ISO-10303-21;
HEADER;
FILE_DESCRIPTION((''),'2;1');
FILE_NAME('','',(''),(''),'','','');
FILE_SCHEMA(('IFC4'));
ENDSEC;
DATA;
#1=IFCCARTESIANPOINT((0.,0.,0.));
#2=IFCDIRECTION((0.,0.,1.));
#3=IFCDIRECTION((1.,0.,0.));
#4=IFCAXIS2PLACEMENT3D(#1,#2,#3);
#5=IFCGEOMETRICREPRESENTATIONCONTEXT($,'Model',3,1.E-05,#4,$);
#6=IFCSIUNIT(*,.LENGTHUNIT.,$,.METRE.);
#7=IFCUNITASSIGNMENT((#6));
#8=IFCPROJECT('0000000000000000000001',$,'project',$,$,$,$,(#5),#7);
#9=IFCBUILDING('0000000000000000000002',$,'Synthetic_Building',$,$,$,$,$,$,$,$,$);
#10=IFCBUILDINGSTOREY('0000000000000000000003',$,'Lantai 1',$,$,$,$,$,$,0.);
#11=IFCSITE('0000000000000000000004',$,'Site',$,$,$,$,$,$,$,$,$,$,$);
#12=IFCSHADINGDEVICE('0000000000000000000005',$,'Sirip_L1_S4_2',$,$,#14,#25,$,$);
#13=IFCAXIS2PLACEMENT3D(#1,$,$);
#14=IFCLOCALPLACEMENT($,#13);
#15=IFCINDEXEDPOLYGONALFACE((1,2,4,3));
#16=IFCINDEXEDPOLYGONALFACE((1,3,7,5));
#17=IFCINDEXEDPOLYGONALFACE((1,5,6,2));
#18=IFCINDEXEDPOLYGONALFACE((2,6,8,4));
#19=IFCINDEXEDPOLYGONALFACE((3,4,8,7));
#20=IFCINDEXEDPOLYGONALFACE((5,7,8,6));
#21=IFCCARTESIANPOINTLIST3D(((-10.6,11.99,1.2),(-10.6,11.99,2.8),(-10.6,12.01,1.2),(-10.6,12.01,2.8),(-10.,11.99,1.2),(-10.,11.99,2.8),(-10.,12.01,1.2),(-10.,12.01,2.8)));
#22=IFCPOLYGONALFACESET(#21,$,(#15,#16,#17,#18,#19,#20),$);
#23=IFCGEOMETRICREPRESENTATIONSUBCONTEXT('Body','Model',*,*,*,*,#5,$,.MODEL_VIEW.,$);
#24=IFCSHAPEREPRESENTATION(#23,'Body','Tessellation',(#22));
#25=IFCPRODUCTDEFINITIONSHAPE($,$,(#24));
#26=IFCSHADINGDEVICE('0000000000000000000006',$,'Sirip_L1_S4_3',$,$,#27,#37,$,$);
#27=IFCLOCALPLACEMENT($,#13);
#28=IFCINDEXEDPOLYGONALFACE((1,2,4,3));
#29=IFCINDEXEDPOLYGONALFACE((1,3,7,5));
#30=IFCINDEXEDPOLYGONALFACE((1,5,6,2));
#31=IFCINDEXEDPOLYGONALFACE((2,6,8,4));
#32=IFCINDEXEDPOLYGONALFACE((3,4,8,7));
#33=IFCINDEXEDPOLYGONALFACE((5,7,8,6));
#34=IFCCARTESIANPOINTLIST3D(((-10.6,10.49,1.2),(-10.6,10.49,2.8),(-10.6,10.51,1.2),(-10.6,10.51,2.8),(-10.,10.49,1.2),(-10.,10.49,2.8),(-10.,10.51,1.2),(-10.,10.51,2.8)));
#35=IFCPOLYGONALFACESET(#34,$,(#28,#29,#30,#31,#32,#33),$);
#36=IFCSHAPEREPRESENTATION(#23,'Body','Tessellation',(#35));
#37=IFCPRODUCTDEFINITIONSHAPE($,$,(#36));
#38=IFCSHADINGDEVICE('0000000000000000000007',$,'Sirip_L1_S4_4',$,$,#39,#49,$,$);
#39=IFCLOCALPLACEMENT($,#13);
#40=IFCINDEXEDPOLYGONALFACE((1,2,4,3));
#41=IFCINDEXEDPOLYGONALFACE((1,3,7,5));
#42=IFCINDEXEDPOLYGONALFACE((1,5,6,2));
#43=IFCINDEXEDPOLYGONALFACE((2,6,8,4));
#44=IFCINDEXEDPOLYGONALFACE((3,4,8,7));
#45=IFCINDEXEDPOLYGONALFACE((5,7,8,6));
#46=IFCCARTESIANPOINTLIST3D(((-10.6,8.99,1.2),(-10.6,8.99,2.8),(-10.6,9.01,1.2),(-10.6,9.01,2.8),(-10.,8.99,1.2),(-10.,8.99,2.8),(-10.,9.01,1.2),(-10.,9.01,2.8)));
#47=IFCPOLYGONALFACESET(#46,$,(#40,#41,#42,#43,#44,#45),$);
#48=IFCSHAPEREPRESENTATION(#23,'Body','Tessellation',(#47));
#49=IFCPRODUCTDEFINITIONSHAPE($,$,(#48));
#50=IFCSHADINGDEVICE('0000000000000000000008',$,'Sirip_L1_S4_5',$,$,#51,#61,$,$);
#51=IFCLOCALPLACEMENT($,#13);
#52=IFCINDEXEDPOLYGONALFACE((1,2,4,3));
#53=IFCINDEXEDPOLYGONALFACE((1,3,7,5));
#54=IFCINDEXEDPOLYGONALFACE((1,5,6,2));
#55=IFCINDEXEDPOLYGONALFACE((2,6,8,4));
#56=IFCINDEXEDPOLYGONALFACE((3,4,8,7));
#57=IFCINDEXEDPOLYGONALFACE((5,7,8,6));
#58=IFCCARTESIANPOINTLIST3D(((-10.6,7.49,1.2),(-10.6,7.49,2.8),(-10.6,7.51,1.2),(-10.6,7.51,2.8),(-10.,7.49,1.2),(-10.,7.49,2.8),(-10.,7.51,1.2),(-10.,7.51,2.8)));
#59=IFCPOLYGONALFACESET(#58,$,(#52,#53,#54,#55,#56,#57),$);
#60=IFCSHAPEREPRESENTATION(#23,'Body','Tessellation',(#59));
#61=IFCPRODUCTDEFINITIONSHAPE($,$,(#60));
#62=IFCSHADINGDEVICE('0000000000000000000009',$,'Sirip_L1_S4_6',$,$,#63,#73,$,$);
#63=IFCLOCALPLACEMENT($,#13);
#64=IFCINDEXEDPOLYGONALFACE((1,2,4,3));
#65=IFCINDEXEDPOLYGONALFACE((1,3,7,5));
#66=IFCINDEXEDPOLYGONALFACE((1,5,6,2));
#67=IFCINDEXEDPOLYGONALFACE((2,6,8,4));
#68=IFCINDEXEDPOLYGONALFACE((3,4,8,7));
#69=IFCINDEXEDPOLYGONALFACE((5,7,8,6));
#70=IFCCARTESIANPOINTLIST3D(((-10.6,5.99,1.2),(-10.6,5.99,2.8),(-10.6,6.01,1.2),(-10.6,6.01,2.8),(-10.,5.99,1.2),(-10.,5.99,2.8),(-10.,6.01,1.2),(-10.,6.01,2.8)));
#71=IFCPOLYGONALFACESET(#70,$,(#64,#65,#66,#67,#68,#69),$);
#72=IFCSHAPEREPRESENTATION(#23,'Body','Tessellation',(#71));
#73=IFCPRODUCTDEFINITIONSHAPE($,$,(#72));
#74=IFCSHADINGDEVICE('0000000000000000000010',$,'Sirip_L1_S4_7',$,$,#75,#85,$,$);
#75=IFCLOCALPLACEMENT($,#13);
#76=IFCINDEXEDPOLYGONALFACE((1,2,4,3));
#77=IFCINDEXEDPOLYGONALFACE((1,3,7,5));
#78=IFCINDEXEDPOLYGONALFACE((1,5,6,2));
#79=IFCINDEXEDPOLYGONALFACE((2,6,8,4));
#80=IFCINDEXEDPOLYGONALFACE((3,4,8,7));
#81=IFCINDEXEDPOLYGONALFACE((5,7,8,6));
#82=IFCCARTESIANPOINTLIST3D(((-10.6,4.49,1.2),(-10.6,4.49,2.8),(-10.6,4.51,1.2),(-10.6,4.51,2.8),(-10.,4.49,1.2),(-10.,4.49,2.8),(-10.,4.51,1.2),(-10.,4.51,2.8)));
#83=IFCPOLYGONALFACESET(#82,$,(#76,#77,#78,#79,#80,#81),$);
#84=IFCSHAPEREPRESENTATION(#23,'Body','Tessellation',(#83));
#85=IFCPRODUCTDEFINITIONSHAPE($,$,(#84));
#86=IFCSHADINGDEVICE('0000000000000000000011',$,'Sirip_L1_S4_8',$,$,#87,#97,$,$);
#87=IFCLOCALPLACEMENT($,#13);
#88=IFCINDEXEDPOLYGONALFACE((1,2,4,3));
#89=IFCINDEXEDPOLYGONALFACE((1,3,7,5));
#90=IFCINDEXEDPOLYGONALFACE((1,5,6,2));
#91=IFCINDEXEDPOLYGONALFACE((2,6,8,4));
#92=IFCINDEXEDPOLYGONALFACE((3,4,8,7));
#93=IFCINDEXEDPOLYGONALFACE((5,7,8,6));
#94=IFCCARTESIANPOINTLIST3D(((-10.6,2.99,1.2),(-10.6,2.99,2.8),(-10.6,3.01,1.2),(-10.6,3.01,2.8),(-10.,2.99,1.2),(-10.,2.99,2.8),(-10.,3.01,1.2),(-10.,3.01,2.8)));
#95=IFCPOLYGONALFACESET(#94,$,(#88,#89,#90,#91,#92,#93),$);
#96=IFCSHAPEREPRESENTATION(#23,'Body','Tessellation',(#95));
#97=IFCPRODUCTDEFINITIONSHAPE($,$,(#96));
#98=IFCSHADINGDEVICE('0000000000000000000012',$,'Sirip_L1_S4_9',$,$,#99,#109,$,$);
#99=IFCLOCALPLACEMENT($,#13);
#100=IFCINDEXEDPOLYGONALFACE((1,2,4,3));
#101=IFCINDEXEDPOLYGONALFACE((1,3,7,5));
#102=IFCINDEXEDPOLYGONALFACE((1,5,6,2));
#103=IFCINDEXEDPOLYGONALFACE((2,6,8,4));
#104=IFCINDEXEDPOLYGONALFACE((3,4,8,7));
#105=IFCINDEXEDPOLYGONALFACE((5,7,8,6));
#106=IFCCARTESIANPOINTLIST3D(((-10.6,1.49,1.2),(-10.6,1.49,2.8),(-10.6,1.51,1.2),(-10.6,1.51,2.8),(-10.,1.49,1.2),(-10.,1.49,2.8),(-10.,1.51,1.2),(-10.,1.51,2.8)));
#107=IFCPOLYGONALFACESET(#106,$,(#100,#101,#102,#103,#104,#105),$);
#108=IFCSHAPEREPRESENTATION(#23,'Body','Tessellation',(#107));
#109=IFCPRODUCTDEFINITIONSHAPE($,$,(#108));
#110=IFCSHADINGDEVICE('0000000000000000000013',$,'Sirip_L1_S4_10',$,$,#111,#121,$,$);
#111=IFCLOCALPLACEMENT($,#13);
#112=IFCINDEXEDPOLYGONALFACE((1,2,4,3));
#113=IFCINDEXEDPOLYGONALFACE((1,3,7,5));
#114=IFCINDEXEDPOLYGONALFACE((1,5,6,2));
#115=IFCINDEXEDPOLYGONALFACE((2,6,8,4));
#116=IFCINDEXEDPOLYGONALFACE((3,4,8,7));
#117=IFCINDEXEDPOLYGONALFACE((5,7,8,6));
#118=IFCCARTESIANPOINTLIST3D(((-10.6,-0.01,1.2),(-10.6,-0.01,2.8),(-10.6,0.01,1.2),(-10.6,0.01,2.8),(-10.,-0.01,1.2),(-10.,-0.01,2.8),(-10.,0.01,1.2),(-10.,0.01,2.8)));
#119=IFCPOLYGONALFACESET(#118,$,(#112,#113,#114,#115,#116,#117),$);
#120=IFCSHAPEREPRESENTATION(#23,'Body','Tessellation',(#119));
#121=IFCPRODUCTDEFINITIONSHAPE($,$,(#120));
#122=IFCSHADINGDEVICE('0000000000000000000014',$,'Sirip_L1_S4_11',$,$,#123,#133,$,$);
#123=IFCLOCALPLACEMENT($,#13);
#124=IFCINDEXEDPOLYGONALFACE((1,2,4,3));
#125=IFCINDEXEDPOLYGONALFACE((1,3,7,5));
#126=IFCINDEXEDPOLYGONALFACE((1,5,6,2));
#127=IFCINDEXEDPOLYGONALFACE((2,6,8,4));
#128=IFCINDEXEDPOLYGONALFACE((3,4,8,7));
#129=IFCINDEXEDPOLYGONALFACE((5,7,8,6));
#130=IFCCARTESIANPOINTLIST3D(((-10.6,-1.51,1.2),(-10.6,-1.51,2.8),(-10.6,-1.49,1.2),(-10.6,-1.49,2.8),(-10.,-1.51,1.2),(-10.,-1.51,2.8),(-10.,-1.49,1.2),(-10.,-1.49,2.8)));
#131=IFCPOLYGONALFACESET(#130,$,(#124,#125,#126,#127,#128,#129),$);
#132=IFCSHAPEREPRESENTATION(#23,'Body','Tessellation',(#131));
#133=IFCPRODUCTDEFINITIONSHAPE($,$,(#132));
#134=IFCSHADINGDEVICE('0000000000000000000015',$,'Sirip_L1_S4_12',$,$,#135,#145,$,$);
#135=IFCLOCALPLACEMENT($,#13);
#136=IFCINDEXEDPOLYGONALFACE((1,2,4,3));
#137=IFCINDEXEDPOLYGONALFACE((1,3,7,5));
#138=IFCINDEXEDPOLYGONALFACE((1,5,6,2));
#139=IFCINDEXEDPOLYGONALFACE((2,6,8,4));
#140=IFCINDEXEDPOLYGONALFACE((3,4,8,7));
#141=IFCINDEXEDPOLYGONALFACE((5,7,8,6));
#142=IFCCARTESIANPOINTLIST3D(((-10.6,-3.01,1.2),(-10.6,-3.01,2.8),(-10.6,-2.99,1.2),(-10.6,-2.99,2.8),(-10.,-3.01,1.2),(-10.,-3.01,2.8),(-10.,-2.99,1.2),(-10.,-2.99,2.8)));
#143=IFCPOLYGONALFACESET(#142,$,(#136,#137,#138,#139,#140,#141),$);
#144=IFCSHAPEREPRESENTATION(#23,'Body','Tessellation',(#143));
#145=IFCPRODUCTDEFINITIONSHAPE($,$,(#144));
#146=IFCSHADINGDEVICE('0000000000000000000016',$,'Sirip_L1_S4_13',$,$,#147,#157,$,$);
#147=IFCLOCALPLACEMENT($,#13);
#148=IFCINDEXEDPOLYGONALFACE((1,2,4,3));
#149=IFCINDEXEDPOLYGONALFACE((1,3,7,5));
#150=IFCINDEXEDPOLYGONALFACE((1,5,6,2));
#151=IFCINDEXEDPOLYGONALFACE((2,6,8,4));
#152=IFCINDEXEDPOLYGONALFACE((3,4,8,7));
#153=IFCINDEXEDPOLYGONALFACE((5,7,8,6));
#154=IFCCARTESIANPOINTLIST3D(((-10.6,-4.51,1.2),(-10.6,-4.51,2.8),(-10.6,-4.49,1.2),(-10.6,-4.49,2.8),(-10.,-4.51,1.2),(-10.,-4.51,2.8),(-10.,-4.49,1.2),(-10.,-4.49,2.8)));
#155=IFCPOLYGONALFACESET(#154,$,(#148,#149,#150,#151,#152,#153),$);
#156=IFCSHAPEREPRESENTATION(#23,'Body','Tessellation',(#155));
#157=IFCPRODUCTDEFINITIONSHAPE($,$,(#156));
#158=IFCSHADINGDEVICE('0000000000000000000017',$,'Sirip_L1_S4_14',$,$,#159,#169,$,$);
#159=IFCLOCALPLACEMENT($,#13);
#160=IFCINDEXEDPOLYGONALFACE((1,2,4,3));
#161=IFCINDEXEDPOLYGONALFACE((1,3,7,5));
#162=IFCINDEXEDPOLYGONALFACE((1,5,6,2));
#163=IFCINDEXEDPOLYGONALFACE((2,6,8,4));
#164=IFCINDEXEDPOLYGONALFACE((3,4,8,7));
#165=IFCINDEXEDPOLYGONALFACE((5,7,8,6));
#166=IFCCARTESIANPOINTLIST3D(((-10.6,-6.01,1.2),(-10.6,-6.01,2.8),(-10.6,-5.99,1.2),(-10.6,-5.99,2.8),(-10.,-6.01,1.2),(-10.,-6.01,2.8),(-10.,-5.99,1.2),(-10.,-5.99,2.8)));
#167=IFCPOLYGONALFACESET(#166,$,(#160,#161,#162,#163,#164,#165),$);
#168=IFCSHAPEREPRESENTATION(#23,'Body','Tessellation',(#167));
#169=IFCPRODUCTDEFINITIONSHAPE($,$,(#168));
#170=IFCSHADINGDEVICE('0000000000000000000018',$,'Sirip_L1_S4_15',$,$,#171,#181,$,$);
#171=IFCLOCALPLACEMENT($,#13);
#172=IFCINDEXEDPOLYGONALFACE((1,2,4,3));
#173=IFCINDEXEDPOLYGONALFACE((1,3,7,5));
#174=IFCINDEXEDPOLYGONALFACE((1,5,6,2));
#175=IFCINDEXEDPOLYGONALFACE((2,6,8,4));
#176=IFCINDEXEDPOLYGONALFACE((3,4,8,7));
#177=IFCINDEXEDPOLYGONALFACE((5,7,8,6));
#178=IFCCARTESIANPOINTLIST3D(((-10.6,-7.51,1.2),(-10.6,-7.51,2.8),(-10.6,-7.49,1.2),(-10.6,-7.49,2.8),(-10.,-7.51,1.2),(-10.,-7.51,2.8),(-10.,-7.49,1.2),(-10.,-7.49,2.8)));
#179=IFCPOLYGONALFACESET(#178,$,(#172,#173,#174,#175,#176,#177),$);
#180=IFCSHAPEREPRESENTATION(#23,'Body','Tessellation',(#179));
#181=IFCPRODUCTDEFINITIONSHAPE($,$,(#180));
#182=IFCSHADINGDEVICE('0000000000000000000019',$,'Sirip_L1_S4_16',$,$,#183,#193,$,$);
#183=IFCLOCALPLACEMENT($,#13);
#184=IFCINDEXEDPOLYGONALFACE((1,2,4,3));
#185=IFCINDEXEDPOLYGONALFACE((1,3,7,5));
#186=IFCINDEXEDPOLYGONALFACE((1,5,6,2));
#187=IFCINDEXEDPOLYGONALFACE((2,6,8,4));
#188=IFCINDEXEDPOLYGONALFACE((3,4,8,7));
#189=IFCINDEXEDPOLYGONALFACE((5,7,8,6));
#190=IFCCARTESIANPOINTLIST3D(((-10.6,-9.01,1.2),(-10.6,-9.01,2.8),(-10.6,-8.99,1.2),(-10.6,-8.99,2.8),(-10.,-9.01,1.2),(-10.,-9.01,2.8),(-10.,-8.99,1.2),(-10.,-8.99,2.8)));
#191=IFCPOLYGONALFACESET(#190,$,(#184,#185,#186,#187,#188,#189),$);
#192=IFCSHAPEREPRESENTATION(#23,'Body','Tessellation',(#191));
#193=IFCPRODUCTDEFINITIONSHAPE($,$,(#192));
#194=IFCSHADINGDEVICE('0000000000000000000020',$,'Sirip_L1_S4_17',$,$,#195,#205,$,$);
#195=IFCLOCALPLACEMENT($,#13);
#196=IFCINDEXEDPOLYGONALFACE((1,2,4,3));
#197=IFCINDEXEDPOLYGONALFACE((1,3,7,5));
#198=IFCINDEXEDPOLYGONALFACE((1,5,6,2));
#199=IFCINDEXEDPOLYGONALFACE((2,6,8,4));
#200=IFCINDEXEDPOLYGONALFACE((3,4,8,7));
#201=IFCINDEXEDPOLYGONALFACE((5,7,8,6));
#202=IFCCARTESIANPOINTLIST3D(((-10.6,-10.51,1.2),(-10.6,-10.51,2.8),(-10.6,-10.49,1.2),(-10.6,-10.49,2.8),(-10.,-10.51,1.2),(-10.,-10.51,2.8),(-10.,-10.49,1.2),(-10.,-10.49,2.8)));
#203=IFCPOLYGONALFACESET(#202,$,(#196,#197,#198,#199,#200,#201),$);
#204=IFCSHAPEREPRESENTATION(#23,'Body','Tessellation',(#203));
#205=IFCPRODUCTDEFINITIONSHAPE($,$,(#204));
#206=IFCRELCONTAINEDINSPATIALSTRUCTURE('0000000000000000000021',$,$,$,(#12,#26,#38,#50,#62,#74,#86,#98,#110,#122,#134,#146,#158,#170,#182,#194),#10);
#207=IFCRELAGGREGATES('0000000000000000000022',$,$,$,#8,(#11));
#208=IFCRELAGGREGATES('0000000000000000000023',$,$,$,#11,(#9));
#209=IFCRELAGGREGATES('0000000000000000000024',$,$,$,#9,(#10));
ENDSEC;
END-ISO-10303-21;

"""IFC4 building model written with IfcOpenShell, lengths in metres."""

from ifc_helpers import new_model, si_unit, frame, origin_with_axes, place, context, subcontext, project, spatial, polyline, outline, extrude, element, save


model = new_model("IFC4")

# Units and contexts
model_context = context("Model", 3, precision=1e-05, world=origin_with_axes())
body_context = subcontext(model_context, "Body", "Model", "MODEL_VIEW")
ifc_project = project(units=[si_unit("LENGTHUNIT", "METRE")], contexts=[model_context])

# Site, building, storey
site = spatial("IfcSite", under=ifc_project, Name="Site")
building = spatial("IfcBuilding", under=site, Name="Synthetic_Building")
storey = spatial("IfcBuildingStorey", under=building, Name="Lantai 1", Elevation=0.0)

# Shading devices
shading_device_1_placement = place(None, origin_with_axes())
element("IfcShadingDevice", 1, at=shading_device_1_placement, inside=storey, Name="Sirip_L1_S4_2", context=body_context, shape_type="SweptSolid", body=[
    extrude(outline(polyline([(-10.0, 12.01), (-10.0, 11.99), (-10.6, 11.99), (-10.6, 12.01), (-10.0, 12.01)])), frame((0.0, 0.0, 1.2), z_axis=(0.0, 0.0, 1.0), x_axis=(1.0, 0.0, 0.0)), (0.0, 0.0, 1.0), 1.6),
])
shading_device_2_placement = place(None, origin_with_axes())
element("IfcShadingDevice", 2, at=shading_device_2_placement, inside=storey, Name="Sirip_L1_S4_3", context=body_context, shape_type="SweptSolid", body=[
    extrude(outline(polyline([(-10.0, 10.51), (-10.0, 10.49), (-10.6, 10.49), (-10.6, 10.51), (-10.0, 10.51)])), frame((0.0, 0.0, 1.2), z_axis=(0.0, 0.0, 1.0), x_axis=(1.0, 0.0, 0.0)), (0.0, 0.0, 1.0), 1.6),
])
shading_device_3_placement = place(None, origin_with_axes())
element("IfcShadingDevice", 3, at=shading_device_3_placement, inside=storey, Name="Sirip_L1_S4_4", context=body_context, shape_type="SweptSolid", body=[
    extrude(outline(polyline([(-10.0, 9.01), (-10.0, 8.99), (-10.6, 8.99), (-10.6, 9.01), (-10.0, 9.01)])), frame((0.0, 0.0, 1.2), z_axis=(0.0, 0.0, 1.0), x_axis=(1.0, 0.0, 0.0)), (0.0, 0.0, 1.0), 1.6),
])
shading_device_4_placement = place(None, origin_with_axes())
element("IfcShadingDevice", 4, at=shading_device_4_placement, inside=storey, Name="Sirip_L1_S4_5", context=body_context, shape_type="SweptSolid", body=[
    extrude(outline(polyline([(-10.0, 7.51), (-10.0, 7.49), (-10.6, 7.49), (-10.6, 7.51), (-10.0, 7.51)])), frame((0.0, 0.0, 1.2), z_axis=(0.0, 0.0, 1.0), x_axis=(1.0, 0.0, 0.0)), (0.0, 0.0, 1.0), 1.6),
])
shading_device_5_placement = place(None, origin_with_axes())
element("IfcShadingDevice", 5, at=shading_device_5_placement, inside=storey, Name="Sirip_L1_S4_6", context=body_context, shape_type="SweptSolid", body=[
    extrude(outline(polyline([(-10.0, 6.01), (-10.0, 5.99), (-10.6, 5.99), (-10.6, 6.01), (-10.0, 6.01)])), frame((0.0, 0.0, 1.2), z_axis=(0.0, 0.0, 1.0), x_axis=(1.0, 0.0, 0.0)), (0.0, 0.0, 1.0), 1.6),
])
shading_device_6_placement = place(None, origin_with_axes())
element("IfcShadingDevice", 6, at=shading_device_6_placement, inside=storey, Name="Sirip_L1_S4_7", context=body_context, shape_type="SweptSolid", body=[
    extrude(outline(polyline([(-10.0, 4.51), (-10.0, 4.49), (-10.6, 4.49), (-10.6, 4.51), (-10.0, 4.51)])), frame((0.0, 0.0, 1.2), z_axis=(0.0, 0.0, 1.0), x_axis=(1.0, 0.0, 0.0)), (0.0, 0.0, 1.0), 1.6),
])
shading_device_7_placement = place(None, origin_with_axes())
element("IfcShadingDevice", 7, at=shading_device_7_placement, inside=storey, Name="Sirip_L1_S4_8", context=body_context, shape_type="SweptSolid", body=[
    extrude(outline(polyline([(-10.0, 3.01), (-10.0, 2.99), (-10.6, 2.99), (-10.6, 3.01), (-10.0, 3.01)])), frame((0.0, 0.0, 1.2), z_axis=(0.0, 0.0, 1.0), x_axis=(1.0, 0.0, 0.0)), (0.0, 0.0, 1.0), 1.6),
])
shading_device_8_placement = place(None, origin_with_axes())
element("IfcShadingDevice", 8, at=shading_device_8_placement, inside=storey, Name="Sirip_L1_S4_9", context=body_context, shape_type="SweptSolid", body=[
    extrude(outline(polyline([(-10.0, 1.51), (-10.0, 1.49), (-10.6, 1.49), (-10.6, 1.51), (-10.0, 1.51)])), frame((0.0, 0.0, 1.2), z_axis=(0.0, 0.0, 1.0), x_axis=(1.0, 0.0, 0.0)), (0.0, 0.0, 1.0), 1.6),
])
shading_device_9_placement = place(None, origin_with_axes())
element("IfcShadingDevice", 9, at=shading_device_9_placement, inside=storey, Name="Sirip_L1_S4_10", context=body_context, shape_type="SweptSolid", body=[
    extrude(outline(polyline([(-10.0, 0.01), (-10.0, -0.01), (-10.6, -0.01), (-10.6, 0.01), (-10.0, 0.01)])), frame((0.0, 0.0, 1.2), z_axis=(0.0, 0.0, 1.0), x_axis=(1.0, 0.0, 0.0)), (0.0, 0.0, 1.0), 1.6),
])
shading_device_10_placement = place(None, origin_with_axes())
element("IfcShadingDevice", 10, at=shading_device_10_placement, inside=storey, Name="Sirip_L1_S4_11", context=body_context, shape_type="SweptSolid", body=[
    extrude(outline(polyline([(-10.0, -1.49), (-10.0, -1.51), (-10.6, -1.51), (-10.6, -1.49), (-10.0, -1.49)])), frame((0.0, 0.0, 1.2), z_axis=(0.0, 0.0, 1.0), x_axis=(1.0, 0.0, 0.0)), (0.0, 0.0, 1.0), 1.6),
])
shading_device_11_placement = place(None, origin_with_axes())
element("IfcShadingDevice", 11, at=shading_device_11_placement, inside=storey, Name="Sirip_L1_S4_12", context=body_context, shape_type="SweptSolid", body=[
    extrude(outline(polyline([(-10.0, -2.99), (-10.0, -3.01), (-10.6, -3.01), (-10.6, -2.99), (-10.0, -2.99)])), frame((0.0, 0.0, 1.2), z_axis=(0.0, 0.0, 1.0), x_axis=(1.0, 0.0, 0.0)), (0.0, 0.0, 1.0), 1.6),
])
shading_device_12_placement = place(None, origin_with_axes())
element("IfcShadingDevice", 12, at=shading_device_12_placement, inside=storey, Name="Sirip_L1_S4_13", context=body_context, shape_type="SweptSolid", body=[
    extrude(outline(polyline([(-10.0, -4.49), (-10.0, -4.51), (-10.6, -4.51), (-10.6, -4.49), (-10.0, -4.49)])), frame((0.0, 0.0, 1.2), z_axis=(0.0, 0.0, 1.0), x_axis=(1.0, 0.0, 0.0)), (0.0, 0.0, 1.0), 1.6),
])
shading_device_13_placement = place(None, origin_with_axes())
element("IfcShadingDevice", 13, at=shading_device_13_placement, inside=storey, Name="Sirip_L1_S4_14", context=body_context, shape_type="SweptSolid", body=[
    extrude(outline(polyline([(-10.0, -5.99), (-10.0, -6.01), (-10.6, -6.01), (-10.6, -5.99), (-10.0, -5.99)])), frame((0.0, 0.0, 1.2), z_axis=(0.0, 0.0, 1.0), x_axis=(1.0, 0.0, 0.0)), (0.0, 0.0, 1.0), 1.6),
])
shading_device_14_placement = place(None, origin_with_axes())
element("IfcShadingDevice", 14, at=shading_device_14_placement, inside=storey, Name="Sirip_L1_S4_15", context=body_context, shape_type="SweptSolid", body=[
    extrude(outline(polyline([(-10.0, -7.49), (-10.0, -7.51), (-10.6, -7.51), (-10.6, -7.49), (-10.0, -7.49)])), frame((0.0, 0.0, 1.2), z_axis=(0.0, 0.0, 1.0), x_axis=(1.0, 0.0, 0.0)), (0.0, 0.0, 1.0), 1.6),
])
shading_device_15_placement = place(None, origin_with_axes())
element("IfcShadingDevice", 15, at=shading_device_15_placement, inside=storey, Name="Sirip_L1_S4_16", context=body_context, shape_type="SweptSolid", body=[
    extrude(outline(polyline([(-10.0, -8.99), (-10.0, -9.01), (-10.6, -9.01), (-10.6, -8.99), (-10.0, -8.99)])), frame((0.0, 0.0, 1.2), z_axis=(0.0, 0.0, 1.0), x_axis=(1.0, 0.0, 0.0)), (0.0, 0.0, 1.0), 1.6),
])
shading_device_16_placement = place(None, origin_with_axes())
element("IfcShadingDevice", 16, at=shading_device_16_placement, inside=storey, Name="Sirip_L1_S4_17", context=body_context, shape_type="SweptSolid", body=[
    extrude(outline(polyline([(-10.0, -10.49), (-10.0, -10.51), (-10.6, -10.51), (-10.6, -10.49), (-10.0, -10.49)])), frame((0.0, 0.0, 1.2), z_axis=(0.0, 0.0, 1.0), x_axis=(1.0, 0.0, 0.0)), (0.0, 0.0, 1.0), 1.6),
])

save(model, "model.ifc")
